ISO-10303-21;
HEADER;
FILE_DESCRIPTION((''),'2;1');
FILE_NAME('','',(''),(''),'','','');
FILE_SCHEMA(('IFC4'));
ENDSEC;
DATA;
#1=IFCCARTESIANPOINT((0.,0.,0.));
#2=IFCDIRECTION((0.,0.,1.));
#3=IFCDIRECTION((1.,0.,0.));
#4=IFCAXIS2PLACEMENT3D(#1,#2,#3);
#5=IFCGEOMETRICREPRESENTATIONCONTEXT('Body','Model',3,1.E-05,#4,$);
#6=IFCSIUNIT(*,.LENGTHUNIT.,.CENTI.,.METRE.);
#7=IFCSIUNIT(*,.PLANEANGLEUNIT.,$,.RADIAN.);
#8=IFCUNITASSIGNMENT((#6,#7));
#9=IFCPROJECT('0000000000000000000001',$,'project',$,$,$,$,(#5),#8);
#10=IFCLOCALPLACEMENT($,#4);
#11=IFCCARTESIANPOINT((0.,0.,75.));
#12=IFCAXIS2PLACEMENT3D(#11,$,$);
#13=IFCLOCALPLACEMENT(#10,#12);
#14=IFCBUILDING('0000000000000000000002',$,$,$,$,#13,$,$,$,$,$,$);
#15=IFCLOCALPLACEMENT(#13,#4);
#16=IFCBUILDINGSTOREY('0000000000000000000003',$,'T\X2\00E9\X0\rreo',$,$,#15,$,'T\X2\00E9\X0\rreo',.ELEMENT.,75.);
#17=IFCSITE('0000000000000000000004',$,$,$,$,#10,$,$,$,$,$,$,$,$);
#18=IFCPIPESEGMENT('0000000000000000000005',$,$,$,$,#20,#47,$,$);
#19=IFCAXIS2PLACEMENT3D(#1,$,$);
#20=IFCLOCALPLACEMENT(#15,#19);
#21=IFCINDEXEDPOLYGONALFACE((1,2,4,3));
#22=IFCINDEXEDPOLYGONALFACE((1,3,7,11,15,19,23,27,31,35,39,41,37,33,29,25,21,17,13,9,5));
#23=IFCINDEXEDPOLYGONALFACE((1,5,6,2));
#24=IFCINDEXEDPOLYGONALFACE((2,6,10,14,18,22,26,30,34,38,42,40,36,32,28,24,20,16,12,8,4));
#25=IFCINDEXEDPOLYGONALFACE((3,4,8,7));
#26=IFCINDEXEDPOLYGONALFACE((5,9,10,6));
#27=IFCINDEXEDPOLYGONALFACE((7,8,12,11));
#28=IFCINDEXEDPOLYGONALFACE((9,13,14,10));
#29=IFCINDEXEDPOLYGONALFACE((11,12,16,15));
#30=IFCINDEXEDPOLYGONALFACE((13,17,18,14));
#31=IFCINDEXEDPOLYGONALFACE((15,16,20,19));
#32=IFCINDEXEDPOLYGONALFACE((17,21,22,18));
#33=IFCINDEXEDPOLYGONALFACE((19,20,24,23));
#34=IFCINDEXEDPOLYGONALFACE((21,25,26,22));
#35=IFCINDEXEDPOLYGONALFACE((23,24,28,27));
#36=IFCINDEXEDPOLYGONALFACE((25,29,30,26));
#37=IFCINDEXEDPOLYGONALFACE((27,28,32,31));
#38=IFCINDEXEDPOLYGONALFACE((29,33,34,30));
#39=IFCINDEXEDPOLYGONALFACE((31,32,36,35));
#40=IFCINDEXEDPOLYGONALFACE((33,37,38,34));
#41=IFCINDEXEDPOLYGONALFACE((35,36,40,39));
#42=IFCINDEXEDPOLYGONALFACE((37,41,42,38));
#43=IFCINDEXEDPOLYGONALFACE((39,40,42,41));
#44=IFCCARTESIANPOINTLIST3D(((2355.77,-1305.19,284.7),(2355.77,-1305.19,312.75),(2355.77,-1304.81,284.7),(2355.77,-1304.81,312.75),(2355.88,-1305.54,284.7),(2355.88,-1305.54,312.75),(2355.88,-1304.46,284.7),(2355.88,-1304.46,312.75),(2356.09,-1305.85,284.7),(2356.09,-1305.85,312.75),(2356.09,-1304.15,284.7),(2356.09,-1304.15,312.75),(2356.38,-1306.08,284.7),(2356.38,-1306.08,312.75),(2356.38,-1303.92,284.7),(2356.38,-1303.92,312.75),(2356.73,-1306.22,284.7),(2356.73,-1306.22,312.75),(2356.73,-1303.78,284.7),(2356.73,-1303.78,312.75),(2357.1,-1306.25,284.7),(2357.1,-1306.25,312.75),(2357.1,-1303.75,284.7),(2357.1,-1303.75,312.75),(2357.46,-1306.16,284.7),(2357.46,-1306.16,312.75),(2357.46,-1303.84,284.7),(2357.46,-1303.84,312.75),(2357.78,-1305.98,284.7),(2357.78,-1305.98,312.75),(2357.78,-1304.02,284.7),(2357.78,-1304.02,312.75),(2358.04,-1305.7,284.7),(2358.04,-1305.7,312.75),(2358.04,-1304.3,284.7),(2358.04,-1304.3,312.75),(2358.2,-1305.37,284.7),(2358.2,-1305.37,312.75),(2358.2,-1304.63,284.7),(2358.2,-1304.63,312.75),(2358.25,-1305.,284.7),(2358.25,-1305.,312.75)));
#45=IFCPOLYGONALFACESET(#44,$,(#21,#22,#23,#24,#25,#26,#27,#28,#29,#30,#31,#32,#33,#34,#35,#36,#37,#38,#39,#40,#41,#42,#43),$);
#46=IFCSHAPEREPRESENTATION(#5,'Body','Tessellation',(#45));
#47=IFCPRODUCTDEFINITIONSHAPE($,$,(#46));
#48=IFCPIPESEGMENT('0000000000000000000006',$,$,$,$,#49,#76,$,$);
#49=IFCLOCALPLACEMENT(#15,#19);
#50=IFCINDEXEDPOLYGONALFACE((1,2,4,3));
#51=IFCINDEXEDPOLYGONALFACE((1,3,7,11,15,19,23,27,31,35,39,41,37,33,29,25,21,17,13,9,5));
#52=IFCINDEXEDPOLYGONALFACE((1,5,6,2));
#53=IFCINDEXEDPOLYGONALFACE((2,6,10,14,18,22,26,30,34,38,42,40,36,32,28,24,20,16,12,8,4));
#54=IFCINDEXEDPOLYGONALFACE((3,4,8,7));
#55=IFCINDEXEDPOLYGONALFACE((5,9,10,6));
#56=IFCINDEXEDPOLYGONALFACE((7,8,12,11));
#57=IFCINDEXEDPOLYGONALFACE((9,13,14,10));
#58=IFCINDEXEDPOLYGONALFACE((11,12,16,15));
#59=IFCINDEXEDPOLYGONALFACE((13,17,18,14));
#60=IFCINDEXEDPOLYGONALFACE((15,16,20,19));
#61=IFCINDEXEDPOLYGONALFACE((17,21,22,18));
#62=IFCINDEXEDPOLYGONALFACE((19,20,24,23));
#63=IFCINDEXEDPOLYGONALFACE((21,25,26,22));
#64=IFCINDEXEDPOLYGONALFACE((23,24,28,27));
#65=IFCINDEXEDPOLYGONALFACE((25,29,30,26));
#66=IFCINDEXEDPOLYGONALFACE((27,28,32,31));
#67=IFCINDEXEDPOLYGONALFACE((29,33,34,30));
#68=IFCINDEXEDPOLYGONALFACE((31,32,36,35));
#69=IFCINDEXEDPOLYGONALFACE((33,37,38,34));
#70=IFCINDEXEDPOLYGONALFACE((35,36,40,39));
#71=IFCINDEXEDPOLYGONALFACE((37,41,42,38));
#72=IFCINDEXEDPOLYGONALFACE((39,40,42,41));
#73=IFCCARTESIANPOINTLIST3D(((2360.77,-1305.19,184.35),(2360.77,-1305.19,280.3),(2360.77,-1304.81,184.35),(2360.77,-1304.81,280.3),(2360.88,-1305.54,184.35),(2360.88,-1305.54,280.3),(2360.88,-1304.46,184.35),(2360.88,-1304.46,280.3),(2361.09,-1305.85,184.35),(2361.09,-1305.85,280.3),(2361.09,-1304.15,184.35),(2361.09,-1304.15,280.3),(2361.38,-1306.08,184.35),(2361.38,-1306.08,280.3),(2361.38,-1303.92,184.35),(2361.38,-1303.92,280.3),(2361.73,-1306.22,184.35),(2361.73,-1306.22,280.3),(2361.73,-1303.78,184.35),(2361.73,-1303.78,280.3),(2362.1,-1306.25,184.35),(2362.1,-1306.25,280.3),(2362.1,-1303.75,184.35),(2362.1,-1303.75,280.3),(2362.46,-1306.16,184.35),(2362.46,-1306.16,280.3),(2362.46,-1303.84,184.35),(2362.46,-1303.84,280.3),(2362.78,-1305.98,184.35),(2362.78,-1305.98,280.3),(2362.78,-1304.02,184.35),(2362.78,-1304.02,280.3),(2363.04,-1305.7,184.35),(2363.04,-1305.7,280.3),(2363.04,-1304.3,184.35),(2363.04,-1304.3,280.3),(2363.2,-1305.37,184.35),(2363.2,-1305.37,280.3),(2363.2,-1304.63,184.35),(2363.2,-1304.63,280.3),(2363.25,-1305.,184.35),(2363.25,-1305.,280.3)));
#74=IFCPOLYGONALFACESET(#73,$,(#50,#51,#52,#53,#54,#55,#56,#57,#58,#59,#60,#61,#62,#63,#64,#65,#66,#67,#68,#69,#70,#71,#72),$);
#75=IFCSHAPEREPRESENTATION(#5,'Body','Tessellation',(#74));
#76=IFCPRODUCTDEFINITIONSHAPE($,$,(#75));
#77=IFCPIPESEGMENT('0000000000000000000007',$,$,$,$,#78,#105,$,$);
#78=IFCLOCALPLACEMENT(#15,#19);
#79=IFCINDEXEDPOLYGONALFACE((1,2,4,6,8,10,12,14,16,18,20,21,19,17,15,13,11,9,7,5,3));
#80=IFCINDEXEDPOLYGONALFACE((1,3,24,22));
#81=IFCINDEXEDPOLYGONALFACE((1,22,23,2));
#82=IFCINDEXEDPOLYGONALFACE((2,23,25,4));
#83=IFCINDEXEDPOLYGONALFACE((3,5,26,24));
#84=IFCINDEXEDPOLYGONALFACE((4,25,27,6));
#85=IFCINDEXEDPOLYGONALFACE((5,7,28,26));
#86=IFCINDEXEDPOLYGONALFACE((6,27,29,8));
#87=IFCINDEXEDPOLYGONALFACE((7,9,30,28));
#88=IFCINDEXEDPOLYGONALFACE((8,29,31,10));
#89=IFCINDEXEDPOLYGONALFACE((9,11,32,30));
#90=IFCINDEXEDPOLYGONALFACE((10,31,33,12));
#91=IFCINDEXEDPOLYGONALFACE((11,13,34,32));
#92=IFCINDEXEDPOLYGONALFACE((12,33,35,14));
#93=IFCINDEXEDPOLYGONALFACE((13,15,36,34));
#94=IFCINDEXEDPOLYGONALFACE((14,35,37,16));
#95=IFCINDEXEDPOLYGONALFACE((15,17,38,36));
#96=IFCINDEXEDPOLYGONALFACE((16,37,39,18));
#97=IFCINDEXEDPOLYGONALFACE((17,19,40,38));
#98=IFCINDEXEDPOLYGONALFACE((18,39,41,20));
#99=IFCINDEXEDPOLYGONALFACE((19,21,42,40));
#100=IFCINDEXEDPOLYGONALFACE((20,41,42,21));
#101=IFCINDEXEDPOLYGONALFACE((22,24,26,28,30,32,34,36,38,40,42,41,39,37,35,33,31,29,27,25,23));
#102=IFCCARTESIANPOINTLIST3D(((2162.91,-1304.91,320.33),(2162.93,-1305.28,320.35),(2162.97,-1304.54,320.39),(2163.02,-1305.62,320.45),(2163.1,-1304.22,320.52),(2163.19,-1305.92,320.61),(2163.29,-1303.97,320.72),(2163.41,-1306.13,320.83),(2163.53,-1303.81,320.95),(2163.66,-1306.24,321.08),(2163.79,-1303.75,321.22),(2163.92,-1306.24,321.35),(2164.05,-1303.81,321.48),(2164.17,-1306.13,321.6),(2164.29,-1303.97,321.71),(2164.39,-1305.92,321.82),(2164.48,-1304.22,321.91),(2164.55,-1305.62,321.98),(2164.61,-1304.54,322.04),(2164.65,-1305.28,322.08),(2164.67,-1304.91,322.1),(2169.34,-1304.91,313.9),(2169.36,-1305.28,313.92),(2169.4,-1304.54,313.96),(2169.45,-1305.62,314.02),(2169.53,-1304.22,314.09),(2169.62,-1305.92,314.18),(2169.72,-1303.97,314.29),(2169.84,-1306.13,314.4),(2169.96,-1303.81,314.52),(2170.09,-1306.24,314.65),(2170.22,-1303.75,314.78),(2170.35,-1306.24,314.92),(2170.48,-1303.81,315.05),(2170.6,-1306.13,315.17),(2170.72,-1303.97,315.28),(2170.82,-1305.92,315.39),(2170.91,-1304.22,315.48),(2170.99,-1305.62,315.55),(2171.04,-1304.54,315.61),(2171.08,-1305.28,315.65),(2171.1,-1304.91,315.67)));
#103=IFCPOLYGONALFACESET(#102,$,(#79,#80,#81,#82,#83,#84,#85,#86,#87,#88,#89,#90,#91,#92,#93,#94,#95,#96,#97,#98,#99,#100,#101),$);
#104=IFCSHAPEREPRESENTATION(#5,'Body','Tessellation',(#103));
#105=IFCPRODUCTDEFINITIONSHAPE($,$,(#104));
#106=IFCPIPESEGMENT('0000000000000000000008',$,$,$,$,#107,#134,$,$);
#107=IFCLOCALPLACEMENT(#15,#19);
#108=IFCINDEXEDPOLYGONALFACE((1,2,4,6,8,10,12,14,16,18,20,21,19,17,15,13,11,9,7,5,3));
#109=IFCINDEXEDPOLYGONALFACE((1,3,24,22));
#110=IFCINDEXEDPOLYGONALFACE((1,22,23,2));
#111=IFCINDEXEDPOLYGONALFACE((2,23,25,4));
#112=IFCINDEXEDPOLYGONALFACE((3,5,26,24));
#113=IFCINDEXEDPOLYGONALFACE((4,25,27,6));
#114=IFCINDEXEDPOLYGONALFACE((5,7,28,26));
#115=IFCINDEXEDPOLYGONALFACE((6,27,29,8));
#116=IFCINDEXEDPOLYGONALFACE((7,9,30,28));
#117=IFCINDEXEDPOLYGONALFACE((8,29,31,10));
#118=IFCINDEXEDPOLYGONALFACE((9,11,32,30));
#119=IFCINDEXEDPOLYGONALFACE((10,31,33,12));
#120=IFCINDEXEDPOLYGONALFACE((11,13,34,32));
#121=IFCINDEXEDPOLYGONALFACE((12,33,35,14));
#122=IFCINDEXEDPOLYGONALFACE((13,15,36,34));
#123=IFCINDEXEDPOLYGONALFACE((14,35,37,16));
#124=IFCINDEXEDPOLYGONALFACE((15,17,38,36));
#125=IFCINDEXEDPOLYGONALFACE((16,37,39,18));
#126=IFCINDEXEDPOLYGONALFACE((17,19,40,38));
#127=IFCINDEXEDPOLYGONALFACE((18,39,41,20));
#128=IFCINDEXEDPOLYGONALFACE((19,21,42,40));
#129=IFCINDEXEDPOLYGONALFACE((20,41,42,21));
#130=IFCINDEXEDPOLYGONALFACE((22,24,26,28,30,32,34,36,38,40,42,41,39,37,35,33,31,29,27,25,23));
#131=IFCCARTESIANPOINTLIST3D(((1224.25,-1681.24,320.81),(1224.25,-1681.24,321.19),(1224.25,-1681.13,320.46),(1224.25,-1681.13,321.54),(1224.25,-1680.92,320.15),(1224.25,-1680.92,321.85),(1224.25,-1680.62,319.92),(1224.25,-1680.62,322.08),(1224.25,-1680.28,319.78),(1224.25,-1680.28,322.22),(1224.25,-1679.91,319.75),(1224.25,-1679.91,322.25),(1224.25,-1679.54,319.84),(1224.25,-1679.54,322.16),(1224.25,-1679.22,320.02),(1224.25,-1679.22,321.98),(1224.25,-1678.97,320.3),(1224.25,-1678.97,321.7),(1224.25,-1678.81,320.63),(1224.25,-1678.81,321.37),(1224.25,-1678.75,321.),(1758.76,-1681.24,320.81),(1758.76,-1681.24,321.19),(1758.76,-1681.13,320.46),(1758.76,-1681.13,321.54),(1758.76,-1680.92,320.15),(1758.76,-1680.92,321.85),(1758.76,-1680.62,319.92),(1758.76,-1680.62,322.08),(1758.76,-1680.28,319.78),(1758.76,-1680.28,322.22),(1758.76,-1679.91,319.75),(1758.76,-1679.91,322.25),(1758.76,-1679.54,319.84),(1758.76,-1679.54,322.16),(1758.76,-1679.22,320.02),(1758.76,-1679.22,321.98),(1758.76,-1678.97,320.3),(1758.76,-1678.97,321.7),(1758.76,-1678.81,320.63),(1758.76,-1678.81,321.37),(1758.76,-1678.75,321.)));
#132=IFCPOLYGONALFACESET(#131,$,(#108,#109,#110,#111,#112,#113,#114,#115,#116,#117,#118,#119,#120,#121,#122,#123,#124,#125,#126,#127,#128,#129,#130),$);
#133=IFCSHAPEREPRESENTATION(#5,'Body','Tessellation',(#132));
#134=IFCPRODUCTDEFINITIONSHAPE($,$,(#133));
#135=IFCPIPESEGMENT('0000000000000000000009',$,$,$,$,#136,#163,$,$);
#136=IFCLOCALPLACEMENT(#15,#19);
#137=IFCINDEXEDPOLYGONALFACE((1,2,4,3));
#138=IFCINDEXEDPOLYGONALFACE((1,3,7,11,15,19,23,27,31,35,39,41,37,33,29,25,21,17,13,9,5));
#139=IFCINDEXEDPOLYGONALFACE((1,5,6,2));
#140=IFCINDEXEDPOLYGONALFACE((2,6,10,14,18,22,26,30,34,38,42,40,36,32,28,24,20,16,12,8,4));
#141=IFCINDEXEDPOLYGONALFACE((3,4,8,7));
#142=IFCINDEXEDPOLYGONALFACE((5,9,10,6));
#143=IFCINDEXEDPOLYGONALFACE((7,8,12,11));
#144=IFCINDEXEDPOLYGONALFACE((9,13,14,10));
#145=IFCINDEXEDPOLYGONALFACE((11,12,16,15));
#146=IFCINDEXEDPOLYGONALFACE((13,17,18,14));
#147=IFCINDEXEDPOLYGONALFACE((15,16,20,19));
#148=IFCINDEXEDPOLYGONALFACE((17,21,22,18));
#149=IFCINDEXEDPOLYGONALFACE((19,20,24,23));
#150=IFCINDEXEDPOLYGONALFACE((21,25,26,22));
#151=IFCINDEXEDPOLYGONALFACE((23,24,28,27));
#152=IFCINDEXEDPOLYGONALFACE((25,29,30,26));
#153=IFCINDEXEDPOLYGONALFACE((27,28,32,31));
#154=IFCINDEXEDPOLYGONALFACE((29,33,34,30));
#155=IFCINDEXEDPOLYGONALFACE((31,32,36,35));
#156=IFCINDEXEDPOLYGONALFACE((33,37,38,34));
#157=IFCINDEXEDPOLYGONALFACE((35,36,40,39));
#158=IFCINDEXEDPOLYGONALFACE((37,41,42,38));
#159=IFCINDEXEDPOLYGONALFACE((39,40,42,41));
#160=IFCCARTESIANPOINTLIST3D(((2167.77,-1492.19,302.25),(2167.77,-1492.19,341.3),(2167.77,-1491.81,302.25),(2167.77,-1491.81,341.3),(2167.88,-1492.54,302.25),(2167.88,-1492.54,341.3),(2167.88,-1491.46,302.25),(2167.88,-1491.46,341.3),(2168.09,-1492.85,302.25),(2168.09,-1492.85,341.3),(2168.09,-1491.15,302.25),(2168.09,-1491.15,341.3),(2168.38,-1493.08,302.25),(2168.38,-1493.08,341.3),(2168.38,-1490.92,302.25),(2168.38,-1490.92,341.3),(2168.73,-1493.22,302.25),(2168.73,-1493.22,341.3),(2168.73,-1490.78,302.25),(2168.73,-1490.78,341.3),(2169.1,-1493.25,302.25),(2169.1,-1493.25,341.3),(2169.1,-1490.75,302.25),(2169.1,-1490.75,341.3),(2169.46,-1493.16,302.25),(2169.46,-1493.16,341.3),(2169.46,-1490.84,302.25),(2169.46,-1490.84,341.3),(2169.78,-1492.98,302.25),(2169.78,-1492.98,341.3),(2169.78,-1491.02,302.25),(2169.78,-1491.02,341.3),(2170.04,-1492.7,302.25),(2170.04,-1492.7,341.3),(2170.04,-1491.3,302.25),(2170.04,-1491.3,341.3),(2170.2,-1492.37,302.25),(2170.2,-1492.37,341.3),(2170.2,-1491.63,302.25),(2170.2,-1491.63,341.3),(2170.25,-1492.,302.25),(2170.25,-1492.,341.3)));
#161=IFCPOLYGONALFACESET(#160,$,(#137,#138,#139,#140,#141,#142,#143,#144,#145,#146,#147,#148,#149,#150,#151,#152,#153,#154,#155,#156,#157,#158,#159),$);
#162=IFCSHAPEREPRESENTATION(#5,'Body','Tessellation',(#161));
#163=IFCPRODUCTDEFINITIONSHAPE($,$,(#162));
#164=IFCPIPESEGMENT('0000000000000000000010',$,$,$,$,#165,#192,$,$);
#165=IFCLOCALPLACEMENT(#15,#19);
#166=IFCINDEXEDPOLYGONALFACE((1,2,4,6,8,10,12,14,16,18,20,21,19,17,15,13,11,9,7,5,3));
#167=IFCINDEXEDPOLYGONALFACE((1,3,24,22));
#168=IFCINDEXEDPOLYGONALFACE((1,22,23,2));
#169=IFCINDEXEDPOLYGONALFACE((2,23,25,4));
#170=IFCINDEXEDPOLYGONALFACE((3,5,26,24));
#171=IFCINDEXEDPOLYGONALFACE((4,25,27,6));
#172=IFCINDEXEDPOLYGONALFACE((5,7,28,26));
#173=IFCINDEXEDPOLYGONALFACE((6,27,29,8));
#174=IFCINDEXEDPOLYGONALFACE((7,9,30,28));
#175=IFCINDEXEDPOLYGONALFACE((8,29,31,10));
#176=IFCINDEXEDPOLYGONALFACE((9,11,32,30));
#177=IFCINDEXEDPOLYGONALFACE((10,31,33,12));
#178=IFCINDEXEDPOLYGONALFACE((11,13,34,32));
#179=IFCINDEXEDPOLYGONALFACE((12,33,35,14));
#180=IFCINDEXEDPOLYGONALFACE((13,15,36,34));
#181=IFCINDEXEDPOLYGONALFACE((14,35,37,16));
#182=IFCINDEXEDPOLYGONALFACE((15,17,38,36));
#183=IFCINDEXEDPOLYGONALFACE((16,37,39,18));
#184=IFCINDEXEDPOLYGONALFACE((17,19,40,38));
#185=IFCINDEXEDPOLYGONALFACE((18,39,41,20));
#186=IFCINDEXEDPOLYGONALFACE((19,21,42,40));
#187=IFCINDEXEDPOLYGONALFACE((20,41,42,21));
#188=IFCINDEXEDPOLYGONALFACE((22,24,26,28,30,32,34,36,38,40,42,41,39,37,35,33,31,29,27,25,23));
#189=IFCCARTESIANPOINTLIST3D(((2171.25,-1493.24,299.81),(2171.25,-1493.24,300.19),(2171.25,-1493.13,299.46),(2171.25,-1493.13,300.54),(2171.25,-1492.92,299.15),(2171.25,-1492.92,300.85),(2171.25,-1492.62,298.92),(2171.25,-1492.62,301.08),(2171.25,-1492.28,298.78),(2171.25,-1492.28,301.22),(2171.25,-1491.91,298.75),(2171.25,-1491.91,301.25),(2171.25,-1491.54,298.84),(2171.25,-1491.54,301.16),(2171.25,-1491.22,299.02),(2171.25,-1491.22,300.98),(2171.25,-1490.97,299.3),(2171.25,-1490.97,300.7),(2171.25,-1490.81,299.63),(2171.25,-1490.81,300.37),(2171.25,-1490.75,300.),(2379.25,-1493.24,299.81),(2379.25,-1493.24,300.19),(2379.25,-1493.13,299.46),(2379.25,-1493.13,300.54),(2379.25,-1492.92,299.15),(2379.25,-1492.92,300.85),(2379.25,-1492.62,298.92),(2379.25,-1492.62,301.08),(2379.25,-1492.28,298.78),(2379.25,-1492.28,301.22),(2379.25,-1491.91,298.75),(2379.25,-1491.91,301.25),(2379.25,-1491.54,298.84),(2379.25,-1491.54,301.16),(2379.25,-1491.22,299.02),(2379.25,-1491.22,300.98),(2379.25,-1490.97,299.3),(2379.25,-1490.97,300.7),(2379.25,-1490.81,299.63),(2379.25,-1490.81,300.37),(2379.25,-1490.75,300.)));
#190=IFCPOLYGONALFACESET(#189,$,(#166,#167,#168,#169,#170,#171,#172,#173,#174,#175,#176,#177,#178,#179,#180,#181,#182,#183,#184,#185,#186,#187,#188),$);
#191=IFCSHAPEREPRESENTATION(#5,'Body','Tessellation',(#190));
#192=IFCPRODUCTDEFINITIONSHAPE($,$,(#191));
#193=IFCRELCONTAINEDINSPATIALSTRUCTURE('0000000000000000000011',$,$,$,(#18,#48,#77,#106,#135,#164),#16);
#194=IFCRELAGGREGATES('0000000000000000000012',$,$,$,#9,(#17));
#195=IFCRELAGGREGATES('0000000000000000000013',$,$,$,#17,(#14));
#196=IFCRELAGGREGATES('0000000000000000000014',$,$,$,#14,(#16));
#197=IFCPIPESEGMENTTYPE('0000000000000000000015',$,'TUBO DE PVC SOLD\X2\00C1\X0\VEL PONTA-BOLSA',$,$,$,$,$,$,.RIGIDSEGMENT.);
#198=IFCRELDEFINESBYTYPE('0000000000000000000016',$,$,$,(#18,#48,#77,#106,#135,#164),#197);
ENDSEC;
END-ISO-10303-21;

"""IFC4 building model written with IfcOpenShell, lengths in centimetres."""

from ifc_helpers import new_model, si_unit, frame, origin_with_axes, origin_2d_with_axis, place, context, project, spatial, circle, extrude, type_object, element, save


model = new_model("IFC4")

# Units and contexts
model_context = context("Model", 3, precision=1e-05, world=origin_with_axes(), identifier="Body")
ifc_project = project(units=[si_unit("LENGTHUNIT", "METRE", prefix="CENTI"), si_unit("PLANEANGLEUNIT", "RADIAN")], contexts=[model_context])

# Site, building, storey
site_placement = place(None, origin_with_axes())
site = spatial("IfcSite", under=ifc_project, at=site_placement)
building_placement = place(site_placement, frame((0.0, 0.0, 75.0)))
building = spatial("IfcBuilding", under=site, at=building_placement)
storey_placement = place(building_placement, origin_with_axes())
storey = spatial("IfcBuildingStorey", under=building, at=storey_placement, Name="Térreo", LongName="Térreo", CompositionType="ELEMENT", Elevation=75.0)

# Pipe segments
pipe_segment_type_1 = type_object("IfcPipeSegmentType", Name="TUBO DE PVC SOLDÁVEL PONTA-BOLSA", PredefinedType="RIGIDSEGMENT")
pipe_segment_1_placement = place(storey_placement, frame((2357.0, -1305.0, 312.75), z_axis=(0.0, 0.0, 1.0), x_axis=(1.0, 0.0, 0.0)))
element("IfcPipeSegment", 1, at=pipe_segment_1_placement, inside=storey, type_object=pipe_segment_type_1, context=model_context, shape_type="SolidModel", body=[
    extrude(circle(Radius=1.25, at=origin_2d_with_axis()), frame((0.0, 0.0, 0.0), z_axis=(0.0, 0.0, -1.0), x_axis=(1.0, 0.0, 0.0)), (0.0, 0.0, 1.0), 28.05),
])
pipe_segment_2_placement = place(storey_placement, frame((2362.0, -1305.0, 280.3), z_axis=(0.0, 0.0, 1.0), x_axis=(1.0, 0.0, 0.0)))
element("IfcPipeSegment", 2, at=pipe_segment_2_placement, inside=storey, type_object=pipe_segment_type_1, context=model_context, shape_type="SolidModel", body=[
    extrude(circle(Radius=1.25, at=origin_2d_with_axis()), frame((0.0, 0.0, 0.0), z_axis=(0.0, 0.0, -1.0), x_axis=(1.0, 0.0, 0.0)), (0.0, 0.0, 1.0), 95.95),
])
pipe_segment_3_placement = place(storey_placement, frame((2167.0, -1305.0, 322.1), z_axis=(0.0, 0.0, 1.0), x_axis=(1.0, 0.0, 0.0)))
element("IfcPipeSegment", 3, at=pipe_segment_3_placement, inside=storey, type_object=pipe_segment_type_1, context=model_context, shape_type="SolidModel", body=[
    extrude(circle(Radius=1.25, at=origin_2d_with_axis()), frame((-3.22, 0.0, -0.88), z_axis=(0.707107, 0.0, -0.707107), x_axis=(0.0, 1.0, 0.0)), (0.0, 0.0, 1.0), 9.09),
])
pipe_segment_4_placement = place(storey_placement, frame((1491.51, -1680.0, 322.25), z_axis=(0.0, 0.0, 1.0), x_axis=(1.0, 0.0, 0.0)))
element("IfcPipeSegment", 4, at=pipe_segment_4_placement, inside=storey, type_object=pipe_segment_type_1, context=model_context, shape_type="SolidModel", body=[
    extrude(circle(Radius=1.25, at=origin_2d_with_axis()), frame((267.25, 0.0, -1.25), z_axis=(-1.0, 0.0, 0.0), x_axis=(0.0, 1.0, 0.0)), (0.0, 0.0, 1.0), 534.51),
])
pipe_segment_5_placement = place(storey_placement, frame((2169.0, -1492.0, 341.3), z_axis=(0.0, 0.0, 1.0), x_axis=(1.0, 0.0, 0.0)))
element("IfcPipeSegment", 5, at=pipe_segment_5_placement, inside=storey, type_object=pipe_segment_type_1, context=model_context, shape_type="SolidModel", body=[
    extrude(circle(Radius=1.25, at=origin_2d_with_axis()), frame((0.0, 0.0, -39.05), z_axis=(0.0, 0.0, 1.0), x_axis=(1.0, 0.0, 0.0)), (0.0, 0.0, 1.0), 39.05),
])
pipe_segment_6_placement = place(storey_placement, frame((2275.25, -1492.0, 301.25), z_axis=(0.0, 0.0, 1.0), x_axis=(1.0, 0.0, 0.0)))
element("IfcPipeSegment", 6, at=pipe_segment_6_placement, inside=storey, type_object=pipe_segment_type_1, context=model_context, shape_type="SolidModel", body=[
    extrude(circle(Radius=1.25, at=origin_2d_with_axis()), frame((104.0, 0.0, -1.25), z_axis=(-1.0, 0.0, 0.0), x_axis=(0.0, 1.0, 0.0)), (0.0, 0.0, 1.0), 208.0),
])

save(model, "model.ifc")
